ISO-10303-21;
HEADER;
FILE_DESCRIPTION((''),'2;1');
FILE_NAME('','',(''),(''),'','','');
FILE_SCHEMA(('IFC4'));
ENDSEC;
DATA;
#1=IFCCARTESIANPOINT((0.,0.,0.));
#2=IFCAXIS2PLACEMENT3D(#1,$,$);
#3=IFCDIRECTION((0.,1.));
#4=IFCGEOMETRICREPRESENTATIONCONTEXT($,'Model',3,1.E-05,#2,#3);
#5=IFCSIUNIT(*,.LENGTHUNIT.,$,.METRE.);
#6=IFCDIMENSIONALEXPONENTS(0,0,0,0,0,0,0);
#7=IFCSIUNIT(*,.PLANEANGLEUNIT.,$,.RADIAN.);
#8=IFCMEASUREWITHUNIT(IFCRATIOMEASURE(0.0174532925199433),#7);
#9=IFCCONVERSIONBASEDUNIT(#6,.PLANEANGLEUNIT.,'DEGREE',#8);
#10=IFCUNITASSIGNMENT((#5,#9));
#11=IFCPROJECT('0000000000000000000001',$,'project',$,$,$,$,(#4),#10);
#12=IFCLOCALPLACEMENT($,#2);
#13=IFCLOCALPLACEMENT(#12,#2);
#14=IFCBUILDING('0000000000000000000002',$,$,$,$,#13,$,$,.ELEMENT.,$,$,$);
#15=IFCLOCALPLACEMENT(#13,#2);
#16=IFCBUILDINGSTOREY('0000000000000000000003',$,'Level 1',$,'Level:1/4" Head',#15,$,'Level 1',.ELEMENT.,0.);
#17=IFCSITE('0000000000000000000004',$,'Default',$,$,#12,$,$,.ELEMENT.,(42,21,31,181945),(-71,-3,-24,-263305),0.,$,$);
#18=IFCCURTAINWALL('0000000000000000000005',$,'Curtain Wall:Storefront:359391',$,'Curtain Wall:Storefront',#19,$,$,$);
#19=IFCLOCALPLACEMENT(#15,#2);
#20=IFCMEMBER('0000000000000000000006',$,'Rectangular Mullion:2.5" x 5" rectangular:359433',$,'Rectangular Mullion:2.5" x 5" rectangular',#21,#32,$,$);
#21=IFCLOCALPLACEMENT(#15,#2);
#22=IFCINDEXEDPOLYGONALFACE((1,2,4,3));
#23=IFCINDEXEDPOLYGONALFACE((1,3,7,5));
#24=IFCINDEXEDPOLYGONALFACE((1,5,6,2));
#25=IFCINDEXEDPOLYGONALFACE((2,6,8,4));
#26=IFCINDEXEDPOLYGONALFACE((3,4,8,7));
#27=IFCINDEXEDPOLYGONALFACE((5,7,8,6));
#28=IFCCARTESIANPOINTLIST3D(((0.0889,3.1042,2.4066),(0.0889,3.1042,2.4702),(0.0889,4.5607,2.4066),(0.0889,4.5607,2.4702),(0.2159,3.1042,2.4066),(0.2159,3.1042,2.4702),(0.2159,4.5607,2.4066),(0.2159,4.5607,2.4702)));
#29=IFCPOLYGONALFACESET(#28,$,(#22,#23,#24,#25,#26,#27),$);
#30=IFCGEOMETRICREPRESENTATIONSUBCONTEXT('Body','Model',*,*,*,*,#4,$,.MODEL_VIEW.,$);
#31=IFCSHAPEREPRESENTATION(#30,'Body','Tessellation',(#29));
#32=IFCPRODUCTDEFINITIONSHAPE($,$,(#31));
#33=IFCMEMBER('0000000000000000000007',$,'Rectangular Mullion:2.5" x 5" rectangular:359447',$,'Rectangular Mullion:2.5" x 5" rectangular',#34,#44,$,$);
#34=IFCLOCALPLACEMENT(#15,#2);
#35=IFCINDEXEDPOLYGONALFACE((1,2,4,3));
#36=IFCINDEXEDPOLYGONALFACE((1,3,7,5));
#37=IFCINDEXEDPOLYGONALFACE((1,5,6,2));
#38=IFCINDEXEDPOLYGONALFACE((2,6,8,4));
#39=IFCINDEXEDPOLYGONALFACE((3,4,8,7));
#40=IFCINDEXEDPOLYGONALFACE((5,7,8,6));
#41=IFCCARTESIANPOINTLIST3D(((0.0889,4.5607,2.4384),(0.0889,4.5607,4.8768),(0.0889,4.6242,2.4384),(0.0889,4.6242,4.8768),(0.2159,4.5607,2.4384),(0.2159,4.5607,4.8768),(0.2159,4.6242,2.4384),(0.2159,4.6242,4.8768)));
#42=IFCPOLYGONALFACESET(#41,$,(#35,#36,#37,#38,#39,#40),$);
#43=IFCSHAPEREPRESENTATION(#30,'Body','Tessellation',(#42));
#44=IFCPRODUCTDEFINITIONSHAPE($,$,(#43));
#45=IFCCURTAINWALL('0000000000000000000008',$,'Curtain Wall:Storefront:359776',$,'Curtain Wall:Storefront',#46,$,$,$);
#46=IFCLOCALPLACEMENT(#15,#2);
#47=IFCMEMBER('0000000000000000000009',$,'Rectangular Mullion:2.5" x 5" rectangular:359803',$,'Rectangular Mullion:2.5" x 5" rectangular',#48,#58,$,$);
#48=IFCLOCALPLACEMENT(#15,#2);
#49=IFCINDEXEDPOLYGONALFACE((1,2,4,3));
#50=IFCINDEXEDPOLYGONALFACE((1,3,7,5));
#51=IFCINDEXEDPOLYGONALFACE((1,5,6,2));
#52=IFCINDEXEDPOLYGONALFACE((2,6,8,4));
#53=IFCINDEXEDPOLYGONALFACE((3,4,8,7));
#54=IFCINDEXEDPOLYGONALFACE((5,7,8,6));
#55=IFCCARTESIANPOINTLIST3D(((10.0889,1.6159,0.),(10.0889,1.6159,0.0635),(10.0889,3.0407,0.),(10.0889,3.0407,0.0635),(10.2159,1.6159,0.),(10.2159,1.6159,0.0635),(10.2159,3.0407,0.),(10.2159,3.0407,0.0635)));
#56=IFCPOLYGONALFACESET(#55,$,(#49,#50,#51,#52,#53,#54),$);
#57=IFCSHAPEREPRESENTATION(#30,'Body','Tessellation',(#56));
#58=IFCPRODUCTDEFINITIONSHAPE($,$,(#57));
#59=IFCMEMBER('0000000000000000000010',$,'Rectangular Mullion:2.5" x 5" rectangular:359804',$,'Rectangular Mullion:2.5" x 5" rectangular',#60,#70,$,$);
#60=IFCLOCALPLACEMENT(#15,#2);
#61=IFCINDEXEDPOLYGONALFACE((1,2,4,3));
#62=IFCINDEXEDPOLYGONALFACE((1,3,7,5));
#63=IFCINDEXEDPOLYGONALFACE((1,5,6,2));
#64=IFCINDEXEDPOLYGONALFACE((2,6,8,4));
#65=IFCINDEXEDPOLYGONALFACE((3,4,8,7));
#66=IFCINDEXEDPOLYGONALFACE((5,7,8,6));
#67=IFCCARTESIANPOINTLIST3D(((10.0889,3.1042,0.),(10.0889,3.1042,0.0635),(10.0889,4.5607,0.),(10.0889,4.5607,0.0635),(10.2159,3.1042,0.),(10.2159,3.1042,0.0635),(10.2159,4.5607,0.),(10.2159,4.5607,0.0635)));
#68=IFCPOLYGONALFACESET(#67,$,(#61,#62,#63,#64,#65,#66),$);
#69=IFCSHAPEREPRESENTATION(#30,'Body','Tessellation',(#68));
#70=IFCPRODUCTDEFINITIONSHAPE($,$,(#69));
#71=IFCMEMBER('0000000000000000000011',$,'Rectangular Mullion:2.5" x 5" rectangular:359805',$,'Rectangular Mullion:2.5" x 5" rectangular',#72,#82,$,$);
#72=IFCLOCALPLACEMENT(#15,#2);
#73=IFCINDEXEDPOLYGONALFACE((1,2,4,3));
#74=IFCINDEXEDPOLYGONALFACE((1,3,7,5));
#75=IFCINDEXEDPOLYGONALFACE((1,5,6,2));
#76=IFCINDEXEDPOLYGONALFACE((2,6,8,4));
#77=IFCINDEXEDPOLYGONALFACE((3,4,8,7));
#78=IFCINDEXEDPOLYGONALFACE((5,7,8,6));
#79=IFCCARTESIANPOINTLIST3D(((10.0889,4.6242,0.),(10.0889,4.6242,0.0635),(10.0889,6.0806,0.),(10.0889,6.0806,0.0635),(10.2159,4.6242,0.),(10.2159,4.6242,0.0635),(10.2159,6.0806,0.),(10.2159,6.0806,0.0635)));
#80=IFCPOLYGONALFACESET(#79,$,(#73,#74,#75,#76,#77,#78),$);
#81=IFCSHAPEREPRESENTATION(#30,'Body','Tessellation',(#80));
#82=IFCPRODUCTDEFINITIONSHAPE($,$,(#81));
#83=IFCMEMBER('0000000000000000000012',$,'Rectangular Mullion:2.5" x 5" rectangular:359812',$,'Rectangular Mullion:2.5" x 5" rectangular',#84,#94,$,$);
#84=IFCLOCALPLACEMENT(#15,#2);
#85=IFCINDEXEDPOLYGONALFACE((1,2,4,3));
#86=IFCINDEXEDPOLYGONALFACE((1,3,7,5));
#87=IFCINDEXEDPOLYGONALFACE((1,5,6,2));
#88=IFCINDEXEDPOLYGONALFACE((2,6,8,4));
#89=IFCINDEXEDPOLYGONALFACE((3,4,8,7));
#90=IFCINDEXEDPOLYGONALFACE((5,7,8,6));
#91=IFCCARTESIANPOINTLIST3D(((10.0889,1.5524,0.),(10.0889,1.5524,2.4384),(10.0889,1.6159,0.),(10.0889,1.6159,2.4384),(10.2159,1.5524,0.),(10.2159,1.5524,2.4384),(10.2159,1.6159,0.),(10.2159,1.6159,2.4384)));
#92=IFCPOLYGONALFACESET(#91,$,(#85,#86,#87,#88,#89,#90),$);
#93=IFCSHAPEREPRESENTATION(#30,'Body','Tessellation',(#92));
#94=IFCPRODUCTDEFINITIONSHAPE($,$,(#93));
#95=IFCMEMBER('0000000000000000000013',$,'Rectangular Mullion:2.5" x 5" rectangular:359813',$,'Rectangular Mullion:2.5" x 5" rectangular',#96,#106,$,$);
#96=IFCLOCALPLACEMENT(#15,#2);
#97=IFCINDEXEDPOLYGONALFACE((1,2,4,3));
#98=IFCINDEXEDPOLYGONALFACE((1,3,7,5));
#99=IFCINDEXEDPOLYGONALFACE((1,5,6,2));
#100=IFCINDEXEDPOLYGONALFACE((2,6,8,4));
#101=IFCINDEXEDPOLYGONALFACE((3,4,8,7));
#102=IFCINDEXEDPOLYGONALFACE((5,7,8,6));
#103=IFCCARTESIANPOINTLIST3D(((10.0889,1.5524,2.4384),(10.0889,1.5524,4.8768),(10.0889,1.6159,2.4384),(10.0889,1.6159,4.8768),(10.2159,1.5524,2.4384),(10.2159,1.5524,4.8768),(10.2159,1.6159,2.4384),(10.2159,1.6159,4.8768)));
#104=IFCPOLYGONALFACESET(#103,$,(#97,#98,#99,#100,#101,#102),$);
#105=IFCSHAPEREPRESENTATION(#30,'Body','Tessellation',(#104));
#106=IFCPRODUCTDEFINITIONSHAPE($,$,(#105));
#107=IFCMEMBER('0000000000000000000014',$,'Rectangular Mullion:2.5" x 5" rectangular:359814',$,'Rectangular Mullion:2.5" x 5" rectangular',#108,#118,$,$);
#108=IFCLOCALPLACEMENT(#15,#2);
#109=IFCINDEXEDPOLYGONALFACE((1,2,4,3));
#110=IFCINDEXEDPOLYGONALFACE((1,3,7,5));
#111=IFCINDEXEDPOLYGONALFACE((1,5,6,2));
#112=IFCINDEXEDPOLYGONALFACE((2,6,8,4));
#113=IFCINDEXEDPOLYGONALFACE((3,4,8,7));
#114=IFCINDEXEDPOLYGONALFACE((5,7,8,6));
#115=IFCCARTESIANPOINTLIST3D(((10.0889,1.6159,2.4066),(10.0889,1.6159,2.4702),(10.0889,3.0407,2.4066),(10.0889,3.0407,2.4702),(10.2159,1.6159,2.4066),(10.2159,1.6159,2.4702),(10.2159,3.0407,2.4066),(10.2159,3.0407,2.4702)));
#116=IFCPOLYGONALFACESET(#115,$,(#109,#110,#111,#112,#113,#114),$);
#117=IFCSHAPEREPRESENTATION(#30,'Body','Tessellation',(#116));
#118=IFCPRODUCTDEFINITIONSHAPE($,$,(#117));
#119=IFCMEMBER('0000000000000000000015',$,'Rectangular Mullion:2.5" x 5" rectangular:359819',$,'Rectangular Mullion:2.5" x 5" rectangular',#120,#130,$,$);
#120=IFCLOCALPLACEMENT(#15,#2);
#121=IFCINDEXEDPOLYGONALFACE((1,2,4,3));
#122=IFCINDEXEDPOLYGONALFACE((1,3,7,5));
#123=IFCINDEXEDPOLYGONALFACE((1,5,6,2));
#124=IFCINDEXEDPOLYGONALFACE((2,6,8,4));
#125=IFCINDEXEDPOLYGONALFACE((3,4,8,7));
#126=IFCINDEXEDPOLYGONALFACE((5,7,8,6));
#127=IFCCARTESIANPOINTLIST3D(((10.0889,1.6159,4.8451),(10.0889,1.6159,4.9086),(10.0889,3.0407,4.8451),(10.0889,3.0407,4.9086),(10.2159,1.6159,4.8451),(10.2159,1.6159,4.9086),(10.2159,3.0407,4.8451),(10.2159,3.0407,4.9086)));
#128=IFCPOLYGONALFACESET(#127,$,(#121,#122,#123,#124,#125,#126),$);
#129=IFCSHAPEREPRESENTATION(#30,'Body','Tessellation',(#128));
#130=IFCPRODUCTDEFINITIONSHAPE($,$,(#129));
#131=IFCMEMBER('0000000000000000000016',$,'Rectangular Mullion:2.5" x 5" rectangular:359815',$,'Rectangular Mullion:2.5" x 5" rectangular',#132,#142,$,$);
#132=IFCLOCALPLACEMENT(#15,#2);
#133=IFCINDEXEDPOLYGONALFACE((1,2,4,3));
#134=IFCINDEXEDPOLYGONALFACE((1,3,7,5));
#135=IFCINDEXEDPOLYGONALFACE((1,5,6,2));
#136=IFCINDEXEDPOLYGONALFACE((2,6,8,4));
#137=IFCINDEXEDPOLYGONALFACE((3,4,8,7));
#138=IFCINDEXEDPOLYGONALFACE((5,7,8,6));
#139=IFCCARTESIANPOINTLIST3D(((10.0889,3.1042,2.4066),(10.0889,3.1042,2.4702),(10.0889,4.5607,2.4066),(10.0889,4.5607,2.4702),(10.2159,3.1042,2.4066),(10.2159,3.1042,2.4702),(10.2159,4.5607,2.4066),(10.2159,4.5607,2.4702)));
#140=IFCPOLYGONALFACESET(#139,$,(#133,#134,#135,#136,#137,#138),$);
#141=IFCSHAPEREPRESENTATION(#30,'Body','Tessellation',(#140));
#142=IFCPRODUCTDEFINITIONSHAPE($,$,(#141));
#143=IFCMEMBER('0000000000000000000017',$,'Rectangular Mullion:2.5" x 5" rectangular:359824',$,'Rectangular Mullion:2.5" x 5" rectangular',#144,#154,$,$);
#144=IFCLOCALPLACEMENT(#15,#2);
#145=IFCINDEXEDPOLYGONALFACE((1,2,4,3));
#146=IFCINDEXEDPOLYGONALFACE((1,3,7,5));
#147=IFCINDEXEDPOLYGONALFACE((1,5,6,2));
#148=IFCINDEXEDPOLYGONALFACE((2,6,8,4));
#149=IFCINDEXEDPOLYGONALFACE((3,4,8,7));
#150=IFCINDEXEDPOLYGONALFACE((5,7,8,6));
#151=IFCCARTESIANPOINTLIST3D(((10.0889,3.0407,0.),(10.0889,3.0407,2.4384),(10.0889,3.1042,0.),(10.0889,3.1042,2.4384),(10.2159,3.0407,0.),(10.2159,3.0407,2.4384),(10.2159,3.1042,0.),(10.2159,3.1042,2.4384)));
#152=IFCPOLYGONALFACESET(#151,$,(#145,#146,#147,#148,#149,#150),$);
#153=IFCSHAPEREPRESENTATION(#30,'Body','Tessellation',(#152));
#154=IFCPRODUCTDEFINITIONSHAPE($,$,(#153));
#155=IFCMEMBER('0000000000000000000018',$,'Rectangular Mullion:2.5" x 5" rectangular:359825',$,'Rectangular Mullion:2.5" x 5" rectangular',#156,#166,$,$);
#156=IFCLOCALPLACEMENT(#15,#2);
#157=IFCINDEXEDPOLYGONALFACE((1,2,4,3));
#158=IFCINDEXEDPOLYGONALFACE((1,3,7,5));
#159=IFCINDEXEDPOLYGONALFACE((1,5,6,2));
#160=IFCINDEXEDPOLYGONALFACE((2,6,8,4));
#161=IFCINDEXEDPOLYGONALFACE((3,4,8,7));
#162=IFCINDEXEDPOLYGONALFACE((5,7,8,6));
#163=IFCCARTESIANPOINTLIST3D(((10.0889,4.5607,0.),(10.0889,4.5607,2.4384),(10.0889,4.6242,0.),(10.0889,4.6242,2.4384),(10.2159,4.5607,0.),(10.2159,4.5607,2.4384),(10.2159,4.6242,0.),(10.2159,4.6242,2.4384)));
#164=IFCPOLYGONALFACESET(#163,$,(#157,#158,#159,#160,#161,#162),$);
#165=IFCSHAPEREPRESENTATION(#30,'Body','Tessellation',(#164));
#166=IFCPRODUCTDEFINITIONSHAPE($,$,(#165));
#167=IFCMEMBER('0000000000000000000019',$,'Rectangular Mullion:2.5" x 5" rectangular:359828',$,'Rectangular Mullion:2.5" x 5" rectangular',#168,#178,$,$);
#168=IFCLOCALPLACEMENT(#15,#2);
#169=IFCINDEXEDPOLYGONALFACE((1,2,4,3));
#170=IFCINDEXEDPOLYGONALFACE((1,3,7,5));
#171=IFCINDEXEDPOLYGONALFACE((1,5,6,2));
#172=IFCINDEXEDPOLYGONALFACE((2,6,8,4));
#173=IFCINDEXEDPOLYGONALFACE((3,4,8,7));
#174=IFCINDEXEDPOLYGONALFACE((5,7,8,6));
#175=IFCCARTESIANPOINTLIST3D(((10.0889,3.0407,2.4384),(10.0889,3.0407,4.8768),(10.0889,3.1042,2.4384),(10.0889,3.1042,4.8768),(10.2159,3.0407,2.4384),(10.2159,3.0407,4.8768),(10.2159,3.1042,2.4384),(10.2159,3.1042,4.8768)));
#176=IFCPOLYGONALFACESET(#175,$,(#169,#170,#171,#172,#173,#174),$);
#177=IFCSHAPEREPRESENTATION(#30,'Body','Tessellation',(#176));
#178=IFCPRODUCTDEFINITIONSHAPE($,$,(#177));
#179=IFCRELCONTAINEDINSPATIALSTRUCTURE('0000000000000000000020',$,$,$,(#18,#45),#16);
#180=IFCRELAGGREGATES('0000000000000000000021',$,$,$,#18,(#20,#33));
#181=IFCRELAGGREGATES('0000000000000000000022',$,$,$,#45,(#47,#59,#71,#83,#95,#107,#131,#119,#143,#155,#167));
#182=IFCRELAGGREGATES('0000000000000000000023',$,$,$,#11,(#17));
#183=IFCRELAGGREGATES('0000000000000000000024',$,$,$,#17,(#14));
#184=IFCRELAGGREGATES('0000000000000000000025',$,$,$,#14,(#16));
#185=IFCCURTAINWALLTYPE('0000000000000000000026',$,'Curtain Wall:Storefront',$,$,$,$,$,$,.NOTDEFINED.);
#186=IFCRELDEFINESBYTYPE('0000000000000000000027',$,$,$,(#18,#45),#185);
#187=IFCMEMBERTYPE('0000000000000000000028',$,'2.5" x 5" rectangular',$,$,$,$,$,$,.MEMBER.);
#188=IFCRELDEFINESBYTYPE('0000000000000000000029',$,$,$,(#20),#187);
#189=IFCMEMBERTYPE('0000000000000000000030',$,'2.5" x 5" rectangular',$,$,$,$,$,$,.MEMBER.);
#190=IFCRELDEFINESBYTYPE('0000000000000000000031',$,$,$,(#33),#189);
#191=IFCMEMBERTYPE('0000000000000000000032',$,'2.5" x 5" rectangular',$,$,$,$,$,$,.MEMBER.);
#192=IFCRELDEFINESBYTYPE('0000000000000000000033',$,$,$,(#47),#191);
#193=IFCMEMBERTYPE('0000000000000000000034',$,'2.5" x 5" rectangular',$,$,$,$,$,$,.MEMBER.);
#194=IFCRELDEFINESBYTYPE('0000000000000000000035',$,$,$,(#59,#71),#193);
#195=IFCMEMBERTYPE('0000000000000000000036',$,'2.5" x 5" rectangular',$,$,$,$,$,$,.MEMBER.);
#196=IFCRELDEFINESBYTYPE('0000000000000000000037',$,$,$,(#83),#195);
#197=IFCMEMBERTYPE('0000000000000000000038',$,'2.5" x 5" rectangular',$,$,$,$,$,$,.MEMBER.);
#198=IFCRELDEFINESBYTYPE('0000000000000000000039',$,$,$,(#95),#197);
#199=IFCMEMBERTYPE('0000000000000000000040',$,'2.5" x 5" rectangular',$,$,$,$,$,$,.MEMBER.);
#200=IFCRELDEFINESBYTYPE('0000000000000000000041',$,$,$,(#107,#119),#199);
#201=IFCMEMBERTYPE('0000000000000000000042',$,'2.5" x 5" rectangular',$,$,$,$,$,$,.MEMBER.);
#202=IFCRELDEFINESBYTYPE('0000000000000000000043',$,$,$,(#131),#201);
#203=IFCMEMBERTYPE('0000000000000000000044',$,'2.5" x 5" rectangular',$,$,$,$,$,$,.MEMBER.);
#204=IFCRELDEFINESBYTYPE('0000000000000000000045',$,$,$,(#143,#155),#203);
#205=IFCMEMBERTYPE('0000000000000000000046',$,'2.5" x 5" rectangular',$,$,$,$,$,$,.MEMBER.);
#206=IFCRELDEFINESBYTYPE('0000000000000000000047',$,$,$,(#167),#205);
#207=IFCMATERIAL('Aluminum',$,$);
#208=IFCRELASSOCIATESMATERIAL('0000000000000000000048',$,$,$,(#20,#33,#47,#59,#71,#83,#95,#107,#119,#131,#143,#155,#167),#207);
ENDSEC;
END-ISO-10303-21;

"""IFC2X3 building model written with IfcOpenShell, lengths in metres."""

from ifc_helpers import new_model, entity, si_unit, converted_unit, direction, frame, origin, origin_2d_with_axis, place, context, subcontext, project, spatial, rectangle, extrude, source, transform, mapped, material, type_object, type_shapes, element, aggregate, save


model = new_model("IFC2X3")

# Units and contexts
model_context = context("Model", 3, precision=1e-05, world=origin(), true_north=direction((0.0, 1.0)))
body_context = subcontext(model_context, "Body", "Model", "MODEL_VIEW")
ifc_project = project(units=[si_unit("LENGTHUNIT", "METRE"), converted_unit("PLANEANGLEUNIT", "DEGREE", entity("IfcRatioMeasure", 0.0174532925199433), si_unit("PLANEANGLEUNIT", "RADIAN"), dimensions=[0, 0, 0, 0, 0, 0, 0])], contexts=[model_context])

# Site, building, storey
site_placement = place(None, origin())
site = spatial("IfcSite", under=ifc_project, at=site_placement, Name="Default", CompositionType="ELEMENT", RefLatitude=(42, 21, 31, 181945), RefLongitude=(-71, -3, -24, -263305), RefElevation=0.0)
building_placement = place(site_placement, origin())
building = spatial("IfcBuilding", under=site, at=building_placement, CompositionType="ELEMENT")
storey_placement = place(building_placement, origin())
storey = spatial("IfcBuildingStorey", under=building, at=storey_placement, Name="Level 1", ObjectType="Level:1/4\" Head", LongName="Level 1", CompositionType="ELEMENT", Elevation=0.0)

# Curtain wall, members
curtain_wall_type = type_object("IfcCurtainWallType", Name="Curtain Wall:Storefront", PredefinedType="NOTDEFINED")
curtain_wall_1_placement = place(storey_placement, origin())
curtain_wall_1 = element("IfcCurtainWall", 1, at=curtain_wall_1_placement, inside=storey, type_object=curtain_wall_type, Name="Curtain Wall:Storefront:359391", ObjectType="Curtain Wall:Storefront")
ifc_material_1 = material(Name="Aluminum")
member_type_1 = type_object("IfcMemberType", Name="2.5\" x 5\" rectangular", PredefinedType="MEMBER")
shared_shape_1 = source(origin(), body_context, "Body", "SweptSolid", [
    extrude(rectangle(XDim=0.127, YDim=0.0635, at=origin_2d_with_axis()), frame((0.0, 0.0, -1.4565), z_axis=(0.0, 0.0, 1.0), x_axis=(0.0, -1.0, 0.0)), (0.0, 0.0, 1.0), 1.4565),
])
type_shapes(member_type_1, [shared_shape_1])
member_1_placement = place(storey_placement, frame((0.1524, 4.5607, 2.4384), z_axis=(0.0, 1.0, 0.0), x_axis=(0.0, 0.0, 1.0)))
member_1 = element("IfcMember", 2, at=member_1_placement, type_object=member_type_1, material=ifc_material_1, Name="Rectangular Mullion:2.5\" x 5\" rectangular:359433", ObjectType="Rectangular Mullion:2.5\" x 5\" rectangular", context=body_context, shape_type="MappedRepresentation", body=[
    mapped(shared_shape_1, transform((0.0, 0.0, 0.0), scale=1.0)),
])
member_type_2 = type_object("IfcMemberType", Name="2.5\" x 5\" rectangular", PredefinedType="MEMBER")
shared_shape_2 = source(origin(), body_context, "Body", "SweptSolid", [
    extrude(rectangle(XDim=0.127, YDim=0.0635, at=origin_2d_with_axis()), frame((0.0, 0.0, -2.4384), z_axis=(0.0, 0.0, 1.0), x_axis=(0.0, -1.0, 0.0)), (0.0, 0.0, 1.0), 2.4384),
])
type_shapes(member_type_2, [shared_shape_2])
member_2_placement = place(storey_placement, frame((0.1524, 4.5924, 2.4384), z_axis=(0.0, 0.0, -1.0), x_axis=(0.0, 1.0, 0.0)))
member_2 = element("IfcMember", 3, at=member_2_placement, type_object=member_type_2, material=ifc_material_1, Name="Rectangular Mullion:2.5\" x 5\" rectangular:359447", ObjectType="Rectangular Mullion:2.5\" x 5\" rectangular", context=body_context, shape_type="MappedRepresentation", body=[
    mapped(shared_shape_2, transform((0.0, 0.0, 0.0), scale=1.0)),
])
aggregate(curtain_wall_1, [member_1, member_2])

# Curtain wall, members
curtain_wall_2_placement = place(storey_placement, origin())
curtain_wall_2 = element("IfcCurtainWall", 4, at=curtain_wall_2_placement, inside=storey, type_object=curtain_wall_type, Name="Curtain Wall:Storefront:359776", ObjectType="Curtain Wall:Storefront")
member_type_3 = type_object("IfcMemberType", Name="2.5\" x 5\" rectangular", PredefinedType="MEMBER")
shared_shape_3 = source(origin(), body_context, "Body", "SweptSolid", [
    extrude(rectangle(XDim=0.127, YDim=0.0635, at=origin_2d_with_axis()), frame((-0.0318, 0.0, -1.4248), z_axis=(0.0, 0.0, 1.0), x_axis=(0.0, -1.0, 0.0)), (0.0, 0.0, 1.0), 1.4248),
])
type_shapes(member_type_3, [shared_shape_3])
member_3_placement = place(storey_placement, frame((10.1524, 1.6159, 0.0), z_axis=(0.0, -1.0, 0.0), x_axis=(0.0, 0.0, -1.0)))
member_3 = element("IfcMember", 5, at=member_3_placement, type_object=member_type_3, material=ifc_material_1, Name="Rectangular Mullion:2.5\" x 5\" rectangular:359803", ObjectType="Rectangular Mullion:2.5\" x 5\" rectangular", context=body_context, shape_type="MappedRepresentation", body=[
    mapped(shared_shape_3, transform((0.0, 0.0, 0.0), scale=1.0)),
])
member_type_4 = type_object("IfcMemberType", Name="2.5\" x 5\" rectangular", PredefinedType="MEMBER")
shared_shape_4 = source(origin(), body_context, "Body", "SweptSolid", [
    extrude(rectangle(XDim=0.127, YDim=0.0635, at=origin_2d_with_axis()), frame((-0.0318, 0.0, -1.4565), z_axis=(0.0, 0.0, 1.0), x_axis=(0.0, -1.0, 0.0)), (0.0, 0.0, 1.0), 1.4565),
])
type_shapes(member_type_4, [shared_shape_4])
member_4_placement = place(storey_placement, frame((10.1524, 3.1042, 0.0), z_axis=(0.0, -1.0, 0.0), x_axis=(0.0, 0.0, -1.0)))
member_4 = element("IfcMember", 6, at=member_4_placement, type_object=member_type_4, material=ifc_material_1, Name="Rectangular Mullion:2.5\" x 5\" rectangular:359804", ObjectType="Rectangular Mullion:2.5\" x 5\" rectangular", context=body_context, shape_type="MappedRepresentation", body=[
    mapped(shared_shape_4, transform((0.0, 0.0, 0.0), scale=1.0)),
])
member_5_placement = place(storey_placement, frame((10.1524, 4.6242, 0.0), z_axis=(0.0, -1.0, 0.0), x_axis=(0.0, 0.0, -1.0)))
member_5 = element("IfcMember", 7, at=member_5_placement, type_object=member_type_4, material=ifc_material_1, Name="Rectangular Mullion:2.5\" x 5\" rectangular:359805", ObjectType="Rectangular Mullion:2.5\" x 5\" rectangular", context=body_context, shape_type="MappedRepresentation", body=[
    mapped(shared_shape_4, transform((0.0, 0.0, 0.0), scale=1.0)),
])
member_type_5 = type_object("IfcMemberType", Name="2.5\" x 5\" rectangular", PredefinedType="MEMBER")
shared_shape_5 = source(origin(), body_context, "Body", "SweptSolid", [
    extrude(rectangle(XDim=0.127, YDim=0.0635, at=origin_2d_with_axis()), frame((-0.0318, 0.0, -2.4384), z_axis=(0.0, 0.0, 1.0), x_axis=(0.0, -1.0, 0.0)), (0.0, 0.0, 1.0), 2.4384),
])
type_shapes(member_type_5, [shared_shape_5])
member_6_placement = place(storey_placement, frame((10.1524, 1.5524, 2.4384), z_axis=(0.0, 0.0, 1.0), x_axis=(0.0, -1.0, 0.0)))
member_6 = element("IfcMember", 8, at=member_6_placement, type_object=member_type_5, material=ifc_material_1, Name="Rectangular Mullion:2.5\" x 5\" rectangular:359812", ObjectType="Rectangular Mullion:2.5\" x 5\" rectangular", context=body_context, shape_type="MappedRepresentation", body=[
    mapped(shared_shape_5, transform((0.0, 0.0, 0.0), scale=1.0)),
])
member_type_6 = type_object("IfcMemberType", Name="2.5\" x 5\" rectangular", PredefinedType="MEMBER")
shared_shape_6 = source(origin(), body_context, "Body", "SweptSolid", [
    extrude(rectangle(XDim=0.127, YDim=0.0635, at=origin_2d_with_axis()), frame((-0.0318, 0.0, -2.4384), z_axis=(0.0, 0.0, 1.0), x_axis=(0.0, -1.0, 0.0)), (0.0, 0.0, 1.0), 2.4384),
])
type_shapes(member_type_6, [shared_shape_6])
member_7_placement = place(storey_placement, frame((10.1524, 1.5524, 4.8768), z_axis=(0.0, 0.0, 1.0), x_axis=(0.0, -1.0, 0.0)))
member_7 = element("IfcMember", 9, at=member_7_placement, type_object=member_type_6, material=ifc_material_1, Name="Rectangular Mullion:2.5\" x 5\" rectangular:359813", ObjectType="Rectangular Mullion:2.5\" x 5\" rectangular", context=body_context, shape_type="MappedRepresentation", body=[
    mapped(shared_shape_6, transform((0.0, 0.0, 0.0), scale=1.0)),
])
member_type_7 = type_object("IfcMemberType", Name="2.5\" x 5\" rectangular", PredefinedType="MEMBER")
shared_shape_7 = source(origin(), body_context, "Body", "SweptSolid", [
    extrude(rectangle(XDim=0.127, YDim=0.0635, at=origin_2d_with_axis()), frame((0.0, 0.0, -1.4248), z_axis=(0.0, 0.0, 1.0), x_axis=(0.0, -1.0, 0.0)), (0.0, 0.0, 1.0), 1.4248),
])
type_shapes(member_type_7, [shared_shape_7])
member_8_placement = place(storey_placement, frame((10.1524, 3.0407, 2.4384), z_axis=(0.0, 1.0, 0.0), x_axis=(0.0, 0.0, 1.0)))
member_8 = element("IfcMember", 10, at=member_8_placement, type_object=member_type_7, material=ifc_material_1, Name="Rectangular Mullion:2.5\" x 5\" rectangular:359814", ObjectType="Rectangular Mullion:2.5\" x 5\" rectangular", context=body_context, shape_type="MappedRepresentation", body=[
    mapped(shared_shape_7, transform((0.0, 0.0, 0.0), scale=1.0)),
])
member_9_placement = place(storey_placement, frame((10.1524, 3.0407, 4.8768), z_axis=(0.0, 1.0, 0.0), x_axis=(0.0, 0.0, 1.0)))
member_9 = element("IfcMember", 11, at=member_9_placement, type_object=member_type_7, material=ifc_material_1, Name="Rectangular Mullion:2.5\" x 5\" rectangular:359819", ObjectType="Rectangular Mullion:2.5\" x 5\" rectangular", context=body_context, shape_type="MappedRepresentation", body=[
    mapped(shared_shape_7, transform((0.0, 0.0, 0.0), scale=1.0)),
])
member_type_8 = type_object("IfcMemberType", Name="2.5\" x 5\" rectangular", PredefinedType="MEMBER")
shared_shape_8 = source(origin(), body_context, "Body", "SweptSolid", [
    extrude(rectangle(XDim=0.127, YDim=0.0635, at=origin_2d_with_axis()), frame((0.0, 0.0, -1.4565), z_axis=(0.0, 0.0, 1.0), x_axis=(0.0, -1.0, 0.0)), (0.0, 0.0, 1.0), 1.4565),
])
type_shapes(member_type_8, [shared_shape_8])
member_10_placement = place(storey_placement, frame((10.1524, 4.5607, 2.4384), z_axis=(0.0, 1.0, 0.0), x_axis=(0.0, 0.0, 1.0)))
member_10 = element("IfcMember", 12, at=member_10_placement, type_object=member_type_8, material=ifc_material_1, Name="Rectangular Mullion:2.5\" x 5\" rectangular:359815", ObjectType="Rectangular Mullion:2.5\" x 5\" rectangular", context=body_context, shape_type="MappedRepresentation", body=[
    mapped(shared_shape_8, transform((0.0, 0.0, 0.0), scale=1.0)),
])
member_type_9 = type_object("IfcMemberType", Name="2.5\" x 5\" rectangular", PredefinedType="MEMBER")
shared_shape_9 = source(origin(), body_context, "Body", "SweptSolid", [
    extrude(rectangle(XDim=0.127, YDim=0.0635, at=origin_2d_with_axis()), frame((0.0, 0.0, -2.4384), z_axis=(0.0, 0.0, 1.0), x_axis=(0.0, -1.0, 0.0)), (0.0, 0.0, 1.0), 2.4384),
])
type_shapes(member_type_9, [shared_shape_9])
member_11_placement = place(storey_placement, frame((10.1524, 3.0724, 0.0), z_axis=(0.0, 0.0, -1.0), x_axis=(0.0, 1.0, 0.0)))
member_11 = element("IfcMember", 13, at=member_11_placement, type_object=member_type_9, material=ifc_material_1, Name="Rectangular Mullion:2.5\" x 5\" rectangular:359824", ObjectType="Rectangular Mullion:2.5\" x 5\" rectangular", context=body_context, shape_type="MappedRepresentation", body=[
    mapped(shared_shape_9, transform((0.0, 0.0, 0.0), scale=1.0)),
])
member_12_placement = place(storey_placement, frame((10.1524, 4.5924, 0.0), z_axis=(0.0, 0.0, -1.0), x_axis=(0.0, 1.0, 0.0)))
member_12 = element("IfcMember", 14, at=member_12_placement, type_object=member_type_9, material=ifc_material_1, Name="Rectangular Mullion:2.5\" x 5\" rectangular:359825", ObjectType="Rectangular Mullion:2.5\" x 5\" rectangular", context=body_context, shape_type="MappedRepresentation", body=[
    mapped(shared_shape_9, transform((0.0, 0.0, 0.0), scale=1.0)),
])
member_type_10 = type_object("IfcMemberType", Name="2.5\" x 5\" rectangular", PredefinedType="MEMBER")
shared_shape_10 = source(origin(), body_context, "Body", "SweptSolid", [
    extrude(rectangle(XDim=0.127, YDim=0.0635, at=origin_2d_with_axis()), frame((0.0, 0.0, -2.4384), z_axis=(0.0, 0.0, 1.0), x_axis=(0.0, -1.0, 0.0)), (0.0, 0.0, 1.0), 2.4384),
])
type_shapes(member_type_10, [shared_shape_10])
member_13_placement = place(storey_placement, frame((10.1524, 3.0724, 2.4384), z_axis=(0.0, 0.0, -1.0), x_axis=(0.0, 1.0, 0.0)))
member_13 = element("IfcMember", 15, at=member_13_placement, type_object=member_type_10, material=ifc_material_1, Name="Rectangular Mullion:2.5\" x 5\" rectangular:359828", ObjectType="Rectangular Mullion:2.5\" x 5\" rectangular", context=body_context, shape_type="MappedRepresentation", body=[
    mapped(shared_shape_10, transform((0.0, 0.0, 0.0), scale=1.0)),
])
aggregate(curtain_wall_2, [member_3, member_4, member_5, member_6, member_7, member_8, member_10, member_9, member_11, member_12, member_13])

save(model, "model.ifc")
